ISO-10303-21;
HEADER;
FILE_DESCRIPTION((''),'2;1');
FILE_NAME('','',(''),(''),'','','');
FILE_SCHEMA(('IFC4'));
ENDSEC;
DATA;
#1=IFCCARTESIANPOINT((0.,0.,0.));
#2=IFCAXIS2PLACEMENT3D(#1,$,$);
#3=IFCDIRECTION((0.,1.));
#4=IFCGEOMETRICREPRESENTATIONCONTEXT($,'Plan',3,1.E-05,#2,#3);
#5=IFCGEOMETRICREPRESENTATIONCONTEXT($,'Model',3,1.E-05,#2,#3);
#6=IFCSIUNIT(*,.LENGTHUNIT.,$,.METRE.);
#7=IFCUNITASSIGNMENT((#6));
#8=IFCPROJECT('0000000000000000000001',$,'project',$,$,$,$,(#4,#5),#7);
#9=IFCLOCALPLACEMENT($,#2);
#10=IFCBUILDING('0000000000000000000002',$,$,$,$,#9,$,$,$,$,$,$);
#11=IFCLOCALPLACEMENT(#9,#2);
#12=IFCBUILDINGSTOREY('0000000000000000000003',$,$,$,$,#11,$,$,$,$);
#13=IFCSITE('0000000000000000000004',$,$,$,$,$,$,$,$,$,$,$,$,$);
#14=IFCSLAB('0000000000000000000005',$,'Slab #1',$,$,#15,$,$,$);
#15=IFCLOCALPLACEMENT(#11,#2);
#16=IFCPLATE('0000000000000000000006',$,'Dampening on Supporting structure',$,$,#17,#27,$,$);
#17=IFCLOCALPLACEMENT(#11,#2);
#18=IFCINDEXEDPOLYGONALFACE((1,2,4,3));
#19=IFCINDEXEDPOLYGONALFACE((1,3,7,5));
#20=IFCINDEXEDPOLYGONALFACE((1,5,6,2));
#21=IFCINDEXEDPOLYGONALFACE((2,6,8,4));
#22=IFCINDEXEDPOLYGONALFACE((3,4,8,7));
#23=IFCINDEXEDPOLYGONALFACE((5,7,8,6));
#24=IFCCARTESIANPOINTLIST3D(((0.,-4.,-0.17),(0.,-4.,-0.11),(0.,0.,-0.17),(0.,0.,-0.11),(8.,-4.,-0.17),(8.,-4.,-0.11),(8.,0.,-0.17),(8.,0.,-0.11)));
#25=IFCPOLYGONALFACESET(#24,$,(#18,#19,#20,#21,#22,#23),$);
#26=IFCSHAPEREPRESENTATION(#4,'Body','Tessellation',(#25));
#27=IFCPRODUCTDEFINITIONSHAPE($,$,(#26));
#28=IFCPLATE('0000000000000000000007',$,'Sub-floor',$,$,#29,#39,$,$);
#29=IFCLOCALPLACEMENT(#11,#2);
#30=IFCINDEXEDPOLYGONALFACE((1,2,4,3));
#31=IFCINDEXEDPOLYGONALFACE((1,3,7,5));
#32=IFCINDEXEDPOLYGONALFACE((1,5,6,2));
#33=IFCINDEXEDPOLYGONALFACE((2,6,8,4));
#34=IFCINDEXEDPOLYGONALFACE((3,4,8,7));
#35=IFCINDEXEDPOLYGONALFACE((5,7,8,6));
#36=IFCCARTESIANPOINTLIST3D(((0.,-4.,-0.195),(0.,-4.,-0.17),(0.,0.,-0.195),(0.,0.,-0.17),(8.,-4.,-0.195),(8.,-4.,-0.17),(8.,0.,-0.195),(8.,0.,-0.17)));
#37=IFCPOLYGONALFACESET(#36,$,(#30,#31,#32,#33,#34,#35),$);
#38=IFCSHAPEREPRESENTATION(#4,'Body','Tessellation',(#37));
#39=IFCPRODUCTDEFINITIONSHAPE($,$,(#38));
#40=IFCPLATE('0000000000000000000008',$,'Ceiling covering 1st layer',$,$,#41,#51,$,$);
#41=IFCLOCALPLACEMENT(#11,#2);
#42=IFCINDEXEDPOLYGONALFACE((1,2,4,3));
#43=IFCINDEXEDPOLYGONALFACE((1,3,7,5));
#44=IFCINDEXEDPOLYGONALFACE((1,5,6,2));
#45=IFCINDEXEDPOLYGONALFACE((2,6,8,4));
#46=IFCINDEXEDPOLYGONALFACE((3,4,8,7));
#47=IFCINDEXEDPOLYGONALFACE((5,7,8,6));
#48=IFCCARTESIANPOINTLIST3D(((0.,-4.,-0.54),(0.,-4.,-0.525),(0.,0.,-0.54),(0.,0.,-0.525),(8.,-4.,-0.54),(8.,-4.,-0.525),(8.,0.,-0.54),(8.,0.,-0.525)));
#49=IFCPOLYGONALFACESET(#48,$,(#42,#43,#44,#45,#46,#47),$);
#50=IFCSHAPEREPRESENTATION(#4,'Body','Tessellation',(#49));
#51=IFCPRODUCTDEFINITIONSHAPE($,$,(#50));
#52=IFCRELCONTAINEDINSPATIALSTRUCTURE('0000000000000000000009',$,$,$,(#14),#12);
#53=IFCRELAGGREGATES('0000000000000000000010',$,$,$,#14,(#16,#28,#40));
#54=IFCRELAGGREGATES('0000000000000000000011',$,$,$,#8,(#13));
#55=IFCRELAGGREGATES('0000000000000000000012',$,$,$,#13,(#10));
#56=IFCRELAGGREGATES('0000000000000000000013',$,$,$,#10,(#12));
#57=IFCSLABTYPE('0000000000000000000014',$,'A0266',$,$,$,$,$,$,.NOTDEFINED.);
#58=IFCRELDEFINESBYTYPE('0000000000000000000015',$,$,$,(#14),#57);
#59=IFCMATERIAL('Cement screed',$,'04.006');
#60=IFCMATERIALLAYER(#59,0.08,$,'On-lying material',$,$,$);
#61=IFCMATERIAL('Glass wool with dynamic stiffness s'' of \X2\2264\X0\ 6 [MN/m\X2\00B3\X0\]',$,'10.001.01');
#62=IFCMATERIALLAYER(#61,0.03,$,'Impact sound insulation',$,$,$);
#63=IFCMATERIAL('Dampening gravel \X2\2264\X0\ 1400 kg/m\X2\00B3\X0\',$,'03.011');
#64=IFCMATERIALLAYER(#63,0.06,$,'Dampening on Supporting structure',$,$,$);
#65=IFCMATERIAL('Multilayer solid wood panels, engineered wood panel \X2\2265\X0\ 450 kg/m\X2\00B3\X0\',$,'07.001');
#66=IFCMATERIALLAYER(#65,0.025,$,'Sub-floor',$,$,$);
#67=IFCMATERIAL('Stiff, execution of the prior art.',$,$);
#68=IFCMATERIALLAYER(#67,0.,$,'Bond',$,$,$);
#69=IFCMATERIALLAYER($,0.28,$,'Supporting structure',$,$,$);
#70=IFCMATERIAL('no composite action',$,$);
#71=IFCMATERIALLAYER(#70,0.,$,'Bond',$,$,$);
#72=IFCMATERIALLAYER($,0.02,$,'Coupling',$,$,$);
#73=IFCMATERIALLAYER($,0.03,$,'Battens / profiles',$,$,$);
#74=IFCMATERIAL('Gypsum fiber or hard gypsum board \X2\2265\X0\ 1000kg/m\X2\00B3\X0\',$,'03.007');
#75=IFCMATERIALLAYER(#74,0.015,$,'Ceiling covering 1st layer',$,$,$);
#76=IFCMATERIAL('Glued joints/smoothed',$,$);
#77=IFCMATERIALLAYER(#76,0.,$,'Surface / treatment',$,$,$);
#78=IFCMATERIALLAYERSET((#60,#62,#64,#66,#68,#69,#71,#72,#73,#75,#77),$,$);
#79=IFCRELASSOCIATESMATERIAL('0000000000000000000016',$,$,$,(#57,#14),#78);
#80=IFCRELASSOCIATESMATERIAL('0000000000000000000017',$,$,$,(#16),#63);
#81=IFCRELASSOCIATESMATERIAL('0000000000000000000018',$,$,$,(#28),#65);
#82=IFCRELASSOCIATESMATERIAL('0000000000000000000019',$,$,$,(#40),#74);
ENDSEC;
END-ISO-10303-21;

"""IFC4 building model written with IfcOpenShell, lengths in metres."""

from ifc_helpers import new_model, si_unit, direction, frame, frame_2d, origin, place, context, project, spatial, rectangle, extrude, material, layer, layer_set, type_object, element, aggregate, save


model = new_model("IFC4")

# Units and contexts
plan_context = context("Plan", 3, precision=1e-05, world=origin(), true_north=direction((0.0, 1.0)))
model_context = context("Model", 3, precision=1e-05, world=origin(), true_north=direction((0.0, 1.0)))
ifc_project = project(units=[si_unit("LENGTHUNIT", "METRE")], contexts=[plan_context, model_context])

# Site, building, storey
site = spatial("IfcSite", under=ifc_project)
building_placement = place(None, origin())
building = spatial("IfcBuilding", under=site, at=building_placement)
storey_placement = place(building_placement, origin())
storey = spatial("IfcBuildingStorey", under=building, at=storey_placement)

# Slab, plates
ifc_material_1 = material(Name="Cement screed", Category="04.006")
ifc_layer_1 = layer(ifc_material_1, 0.08, Name="On-lying material")
ifc_material_2 = material(Name="Glass wool with dynamic stiffness s' of ≤ 6 [MN/m³]", Category="10.001.01")
ifc_layer_2 = layer(ifc_material_2, 0.03, Name="Impact sound insulation")
ifc_material_3 = material(Name="Dampening gravel ≤ 1400 kg/m³", Category="03.011")
ifc_layer_3 = layer(ifc_material_3, 0.06, Name="Dampening on Supporting structure")
ifc_material_4 = material(Name="Multilayer solid wood panels, engineered wood panel ≥ 450 kg/m³", Category="07.001")
ifc_layer_4 = layer(ifc_material_4, 0.025, Name="Sub-floor")
ifc_material_5 = material(Name="Stiff, execution of the prior art.")
ifc_layer_5 = layer(ifc_material_5, 0.0, Name="Bond")
ifc_layer_6 = layer(None, 0.28, Name="Supporting structure")
ifc_material_6 = material(Name="no composite action")
ifc_layer_7 = layer(ifc_material_6, 0.0, Name="Bond")
ifc_layer_8 = layer(None, 0.02, Name="Coupling")
ifc_layer_9 = layer(None, 0.03, Name="Battens / profiles")
ifc_material_7 = material(Name="Gypsum fiber or hard gypsum board ≥ 1000kg/m³", Category="03.007")
ifc_layer_10 = layer(ifc_material_7, 0.015, Name="Ceiling covering 1st layer")
ifc_material_8 = material(Name="Glued joints/smoothed")
ifc_layer_11 = layer(ifc_material_8, 0.0, Name="Surface / treatment")
ifc_layer_set = layer_set([ifc_layer_1, ifc_layer_2, ifc_layer_3, ifc_layer_4, ifc_layer_5, ifc_layer_6, ifc_layer_7, ifc_layer_8, ifc_layer_9, ifc_layer_10, ifc_layer_11])
slab_type = type_object("IfcSlabType", Name="A0266", PredefinedType="NOTDEFINED", material=ifc_layer_set)
slab_placement = place(None, frame((0.0, 0.0, 0.0), z_axis=(0.0, 0.0, -1.0), x_axis=(1.0, 0.0, 0.0)))
slab = element("IfcSlab", 1, at=slab_placement, inside=storey, type_object=slab_type, material=ifc_layer_set, Name="Slab #1")
plate_1_placement = place(slab_placement, origin())
plate_1 = element("IfcPlate", 2, at=plate_1_placement, material=ifc_material_3, Name="Dampening on Supporting structure", context=plan_context, shape_type="SweptSolid", body=[
    extrude(rectangle(XDim=8.0, YDim=4.0, at=frame_2d((4.0, 2.0), x_axis=(1.0, 0.0))), frame((0.0, 0.0, 0.11), z_axis=(0.0, 0.0, 1.0), x_axis=(1.0, 0.0, 0.0)), (0.0, 0.0, 1.0), 0.06),
])
plate_2_placement = place(slab_placement, origin())
plate_2 = element("IfcPlate", 3, at=plate_2_placement, material=ifc_material_4, Name="Sub-floor", context=plan_context, shape_type="SweptSolid", body=[
    extrude(rectangle(XDim=8.0, YDim=4.0, at=frame_2d((4.0, 2.0), x_axis=(1.0, 0.0))), frame((0.0, 0.0, 0.17), z_axis=(0.0, 0.0, 1.0), x_axis=(1.0, 0.0, 0.0)), (0.0, 0.0, 1.0), 0.025),
])
plate_3_placement = place(slab_placement, origin())
plate_3 = element("IfcPlate", 4, at=plate_3_placement, material=ifc_material_7, Name="Ceiling covering 1st layer", context=plan_context, shape_type="SweptSolid", body=[
    extrude(rectangle(XDim=8.0, YDim=4.0, at=frame_2d((4.0, 2.0), x_axis=(1.0, 0.0))), frame((0.0, 0.0, 0.525), z_axis=(0.0, 0.0, 1.0), x_axis=(1.0, 0.0, 0.0)), (0.0, 0.0, 1.0), 0.015),
])
aggregate(slab, [plate_1, plate_2, plate_3])

save(model, "model.ifc")
